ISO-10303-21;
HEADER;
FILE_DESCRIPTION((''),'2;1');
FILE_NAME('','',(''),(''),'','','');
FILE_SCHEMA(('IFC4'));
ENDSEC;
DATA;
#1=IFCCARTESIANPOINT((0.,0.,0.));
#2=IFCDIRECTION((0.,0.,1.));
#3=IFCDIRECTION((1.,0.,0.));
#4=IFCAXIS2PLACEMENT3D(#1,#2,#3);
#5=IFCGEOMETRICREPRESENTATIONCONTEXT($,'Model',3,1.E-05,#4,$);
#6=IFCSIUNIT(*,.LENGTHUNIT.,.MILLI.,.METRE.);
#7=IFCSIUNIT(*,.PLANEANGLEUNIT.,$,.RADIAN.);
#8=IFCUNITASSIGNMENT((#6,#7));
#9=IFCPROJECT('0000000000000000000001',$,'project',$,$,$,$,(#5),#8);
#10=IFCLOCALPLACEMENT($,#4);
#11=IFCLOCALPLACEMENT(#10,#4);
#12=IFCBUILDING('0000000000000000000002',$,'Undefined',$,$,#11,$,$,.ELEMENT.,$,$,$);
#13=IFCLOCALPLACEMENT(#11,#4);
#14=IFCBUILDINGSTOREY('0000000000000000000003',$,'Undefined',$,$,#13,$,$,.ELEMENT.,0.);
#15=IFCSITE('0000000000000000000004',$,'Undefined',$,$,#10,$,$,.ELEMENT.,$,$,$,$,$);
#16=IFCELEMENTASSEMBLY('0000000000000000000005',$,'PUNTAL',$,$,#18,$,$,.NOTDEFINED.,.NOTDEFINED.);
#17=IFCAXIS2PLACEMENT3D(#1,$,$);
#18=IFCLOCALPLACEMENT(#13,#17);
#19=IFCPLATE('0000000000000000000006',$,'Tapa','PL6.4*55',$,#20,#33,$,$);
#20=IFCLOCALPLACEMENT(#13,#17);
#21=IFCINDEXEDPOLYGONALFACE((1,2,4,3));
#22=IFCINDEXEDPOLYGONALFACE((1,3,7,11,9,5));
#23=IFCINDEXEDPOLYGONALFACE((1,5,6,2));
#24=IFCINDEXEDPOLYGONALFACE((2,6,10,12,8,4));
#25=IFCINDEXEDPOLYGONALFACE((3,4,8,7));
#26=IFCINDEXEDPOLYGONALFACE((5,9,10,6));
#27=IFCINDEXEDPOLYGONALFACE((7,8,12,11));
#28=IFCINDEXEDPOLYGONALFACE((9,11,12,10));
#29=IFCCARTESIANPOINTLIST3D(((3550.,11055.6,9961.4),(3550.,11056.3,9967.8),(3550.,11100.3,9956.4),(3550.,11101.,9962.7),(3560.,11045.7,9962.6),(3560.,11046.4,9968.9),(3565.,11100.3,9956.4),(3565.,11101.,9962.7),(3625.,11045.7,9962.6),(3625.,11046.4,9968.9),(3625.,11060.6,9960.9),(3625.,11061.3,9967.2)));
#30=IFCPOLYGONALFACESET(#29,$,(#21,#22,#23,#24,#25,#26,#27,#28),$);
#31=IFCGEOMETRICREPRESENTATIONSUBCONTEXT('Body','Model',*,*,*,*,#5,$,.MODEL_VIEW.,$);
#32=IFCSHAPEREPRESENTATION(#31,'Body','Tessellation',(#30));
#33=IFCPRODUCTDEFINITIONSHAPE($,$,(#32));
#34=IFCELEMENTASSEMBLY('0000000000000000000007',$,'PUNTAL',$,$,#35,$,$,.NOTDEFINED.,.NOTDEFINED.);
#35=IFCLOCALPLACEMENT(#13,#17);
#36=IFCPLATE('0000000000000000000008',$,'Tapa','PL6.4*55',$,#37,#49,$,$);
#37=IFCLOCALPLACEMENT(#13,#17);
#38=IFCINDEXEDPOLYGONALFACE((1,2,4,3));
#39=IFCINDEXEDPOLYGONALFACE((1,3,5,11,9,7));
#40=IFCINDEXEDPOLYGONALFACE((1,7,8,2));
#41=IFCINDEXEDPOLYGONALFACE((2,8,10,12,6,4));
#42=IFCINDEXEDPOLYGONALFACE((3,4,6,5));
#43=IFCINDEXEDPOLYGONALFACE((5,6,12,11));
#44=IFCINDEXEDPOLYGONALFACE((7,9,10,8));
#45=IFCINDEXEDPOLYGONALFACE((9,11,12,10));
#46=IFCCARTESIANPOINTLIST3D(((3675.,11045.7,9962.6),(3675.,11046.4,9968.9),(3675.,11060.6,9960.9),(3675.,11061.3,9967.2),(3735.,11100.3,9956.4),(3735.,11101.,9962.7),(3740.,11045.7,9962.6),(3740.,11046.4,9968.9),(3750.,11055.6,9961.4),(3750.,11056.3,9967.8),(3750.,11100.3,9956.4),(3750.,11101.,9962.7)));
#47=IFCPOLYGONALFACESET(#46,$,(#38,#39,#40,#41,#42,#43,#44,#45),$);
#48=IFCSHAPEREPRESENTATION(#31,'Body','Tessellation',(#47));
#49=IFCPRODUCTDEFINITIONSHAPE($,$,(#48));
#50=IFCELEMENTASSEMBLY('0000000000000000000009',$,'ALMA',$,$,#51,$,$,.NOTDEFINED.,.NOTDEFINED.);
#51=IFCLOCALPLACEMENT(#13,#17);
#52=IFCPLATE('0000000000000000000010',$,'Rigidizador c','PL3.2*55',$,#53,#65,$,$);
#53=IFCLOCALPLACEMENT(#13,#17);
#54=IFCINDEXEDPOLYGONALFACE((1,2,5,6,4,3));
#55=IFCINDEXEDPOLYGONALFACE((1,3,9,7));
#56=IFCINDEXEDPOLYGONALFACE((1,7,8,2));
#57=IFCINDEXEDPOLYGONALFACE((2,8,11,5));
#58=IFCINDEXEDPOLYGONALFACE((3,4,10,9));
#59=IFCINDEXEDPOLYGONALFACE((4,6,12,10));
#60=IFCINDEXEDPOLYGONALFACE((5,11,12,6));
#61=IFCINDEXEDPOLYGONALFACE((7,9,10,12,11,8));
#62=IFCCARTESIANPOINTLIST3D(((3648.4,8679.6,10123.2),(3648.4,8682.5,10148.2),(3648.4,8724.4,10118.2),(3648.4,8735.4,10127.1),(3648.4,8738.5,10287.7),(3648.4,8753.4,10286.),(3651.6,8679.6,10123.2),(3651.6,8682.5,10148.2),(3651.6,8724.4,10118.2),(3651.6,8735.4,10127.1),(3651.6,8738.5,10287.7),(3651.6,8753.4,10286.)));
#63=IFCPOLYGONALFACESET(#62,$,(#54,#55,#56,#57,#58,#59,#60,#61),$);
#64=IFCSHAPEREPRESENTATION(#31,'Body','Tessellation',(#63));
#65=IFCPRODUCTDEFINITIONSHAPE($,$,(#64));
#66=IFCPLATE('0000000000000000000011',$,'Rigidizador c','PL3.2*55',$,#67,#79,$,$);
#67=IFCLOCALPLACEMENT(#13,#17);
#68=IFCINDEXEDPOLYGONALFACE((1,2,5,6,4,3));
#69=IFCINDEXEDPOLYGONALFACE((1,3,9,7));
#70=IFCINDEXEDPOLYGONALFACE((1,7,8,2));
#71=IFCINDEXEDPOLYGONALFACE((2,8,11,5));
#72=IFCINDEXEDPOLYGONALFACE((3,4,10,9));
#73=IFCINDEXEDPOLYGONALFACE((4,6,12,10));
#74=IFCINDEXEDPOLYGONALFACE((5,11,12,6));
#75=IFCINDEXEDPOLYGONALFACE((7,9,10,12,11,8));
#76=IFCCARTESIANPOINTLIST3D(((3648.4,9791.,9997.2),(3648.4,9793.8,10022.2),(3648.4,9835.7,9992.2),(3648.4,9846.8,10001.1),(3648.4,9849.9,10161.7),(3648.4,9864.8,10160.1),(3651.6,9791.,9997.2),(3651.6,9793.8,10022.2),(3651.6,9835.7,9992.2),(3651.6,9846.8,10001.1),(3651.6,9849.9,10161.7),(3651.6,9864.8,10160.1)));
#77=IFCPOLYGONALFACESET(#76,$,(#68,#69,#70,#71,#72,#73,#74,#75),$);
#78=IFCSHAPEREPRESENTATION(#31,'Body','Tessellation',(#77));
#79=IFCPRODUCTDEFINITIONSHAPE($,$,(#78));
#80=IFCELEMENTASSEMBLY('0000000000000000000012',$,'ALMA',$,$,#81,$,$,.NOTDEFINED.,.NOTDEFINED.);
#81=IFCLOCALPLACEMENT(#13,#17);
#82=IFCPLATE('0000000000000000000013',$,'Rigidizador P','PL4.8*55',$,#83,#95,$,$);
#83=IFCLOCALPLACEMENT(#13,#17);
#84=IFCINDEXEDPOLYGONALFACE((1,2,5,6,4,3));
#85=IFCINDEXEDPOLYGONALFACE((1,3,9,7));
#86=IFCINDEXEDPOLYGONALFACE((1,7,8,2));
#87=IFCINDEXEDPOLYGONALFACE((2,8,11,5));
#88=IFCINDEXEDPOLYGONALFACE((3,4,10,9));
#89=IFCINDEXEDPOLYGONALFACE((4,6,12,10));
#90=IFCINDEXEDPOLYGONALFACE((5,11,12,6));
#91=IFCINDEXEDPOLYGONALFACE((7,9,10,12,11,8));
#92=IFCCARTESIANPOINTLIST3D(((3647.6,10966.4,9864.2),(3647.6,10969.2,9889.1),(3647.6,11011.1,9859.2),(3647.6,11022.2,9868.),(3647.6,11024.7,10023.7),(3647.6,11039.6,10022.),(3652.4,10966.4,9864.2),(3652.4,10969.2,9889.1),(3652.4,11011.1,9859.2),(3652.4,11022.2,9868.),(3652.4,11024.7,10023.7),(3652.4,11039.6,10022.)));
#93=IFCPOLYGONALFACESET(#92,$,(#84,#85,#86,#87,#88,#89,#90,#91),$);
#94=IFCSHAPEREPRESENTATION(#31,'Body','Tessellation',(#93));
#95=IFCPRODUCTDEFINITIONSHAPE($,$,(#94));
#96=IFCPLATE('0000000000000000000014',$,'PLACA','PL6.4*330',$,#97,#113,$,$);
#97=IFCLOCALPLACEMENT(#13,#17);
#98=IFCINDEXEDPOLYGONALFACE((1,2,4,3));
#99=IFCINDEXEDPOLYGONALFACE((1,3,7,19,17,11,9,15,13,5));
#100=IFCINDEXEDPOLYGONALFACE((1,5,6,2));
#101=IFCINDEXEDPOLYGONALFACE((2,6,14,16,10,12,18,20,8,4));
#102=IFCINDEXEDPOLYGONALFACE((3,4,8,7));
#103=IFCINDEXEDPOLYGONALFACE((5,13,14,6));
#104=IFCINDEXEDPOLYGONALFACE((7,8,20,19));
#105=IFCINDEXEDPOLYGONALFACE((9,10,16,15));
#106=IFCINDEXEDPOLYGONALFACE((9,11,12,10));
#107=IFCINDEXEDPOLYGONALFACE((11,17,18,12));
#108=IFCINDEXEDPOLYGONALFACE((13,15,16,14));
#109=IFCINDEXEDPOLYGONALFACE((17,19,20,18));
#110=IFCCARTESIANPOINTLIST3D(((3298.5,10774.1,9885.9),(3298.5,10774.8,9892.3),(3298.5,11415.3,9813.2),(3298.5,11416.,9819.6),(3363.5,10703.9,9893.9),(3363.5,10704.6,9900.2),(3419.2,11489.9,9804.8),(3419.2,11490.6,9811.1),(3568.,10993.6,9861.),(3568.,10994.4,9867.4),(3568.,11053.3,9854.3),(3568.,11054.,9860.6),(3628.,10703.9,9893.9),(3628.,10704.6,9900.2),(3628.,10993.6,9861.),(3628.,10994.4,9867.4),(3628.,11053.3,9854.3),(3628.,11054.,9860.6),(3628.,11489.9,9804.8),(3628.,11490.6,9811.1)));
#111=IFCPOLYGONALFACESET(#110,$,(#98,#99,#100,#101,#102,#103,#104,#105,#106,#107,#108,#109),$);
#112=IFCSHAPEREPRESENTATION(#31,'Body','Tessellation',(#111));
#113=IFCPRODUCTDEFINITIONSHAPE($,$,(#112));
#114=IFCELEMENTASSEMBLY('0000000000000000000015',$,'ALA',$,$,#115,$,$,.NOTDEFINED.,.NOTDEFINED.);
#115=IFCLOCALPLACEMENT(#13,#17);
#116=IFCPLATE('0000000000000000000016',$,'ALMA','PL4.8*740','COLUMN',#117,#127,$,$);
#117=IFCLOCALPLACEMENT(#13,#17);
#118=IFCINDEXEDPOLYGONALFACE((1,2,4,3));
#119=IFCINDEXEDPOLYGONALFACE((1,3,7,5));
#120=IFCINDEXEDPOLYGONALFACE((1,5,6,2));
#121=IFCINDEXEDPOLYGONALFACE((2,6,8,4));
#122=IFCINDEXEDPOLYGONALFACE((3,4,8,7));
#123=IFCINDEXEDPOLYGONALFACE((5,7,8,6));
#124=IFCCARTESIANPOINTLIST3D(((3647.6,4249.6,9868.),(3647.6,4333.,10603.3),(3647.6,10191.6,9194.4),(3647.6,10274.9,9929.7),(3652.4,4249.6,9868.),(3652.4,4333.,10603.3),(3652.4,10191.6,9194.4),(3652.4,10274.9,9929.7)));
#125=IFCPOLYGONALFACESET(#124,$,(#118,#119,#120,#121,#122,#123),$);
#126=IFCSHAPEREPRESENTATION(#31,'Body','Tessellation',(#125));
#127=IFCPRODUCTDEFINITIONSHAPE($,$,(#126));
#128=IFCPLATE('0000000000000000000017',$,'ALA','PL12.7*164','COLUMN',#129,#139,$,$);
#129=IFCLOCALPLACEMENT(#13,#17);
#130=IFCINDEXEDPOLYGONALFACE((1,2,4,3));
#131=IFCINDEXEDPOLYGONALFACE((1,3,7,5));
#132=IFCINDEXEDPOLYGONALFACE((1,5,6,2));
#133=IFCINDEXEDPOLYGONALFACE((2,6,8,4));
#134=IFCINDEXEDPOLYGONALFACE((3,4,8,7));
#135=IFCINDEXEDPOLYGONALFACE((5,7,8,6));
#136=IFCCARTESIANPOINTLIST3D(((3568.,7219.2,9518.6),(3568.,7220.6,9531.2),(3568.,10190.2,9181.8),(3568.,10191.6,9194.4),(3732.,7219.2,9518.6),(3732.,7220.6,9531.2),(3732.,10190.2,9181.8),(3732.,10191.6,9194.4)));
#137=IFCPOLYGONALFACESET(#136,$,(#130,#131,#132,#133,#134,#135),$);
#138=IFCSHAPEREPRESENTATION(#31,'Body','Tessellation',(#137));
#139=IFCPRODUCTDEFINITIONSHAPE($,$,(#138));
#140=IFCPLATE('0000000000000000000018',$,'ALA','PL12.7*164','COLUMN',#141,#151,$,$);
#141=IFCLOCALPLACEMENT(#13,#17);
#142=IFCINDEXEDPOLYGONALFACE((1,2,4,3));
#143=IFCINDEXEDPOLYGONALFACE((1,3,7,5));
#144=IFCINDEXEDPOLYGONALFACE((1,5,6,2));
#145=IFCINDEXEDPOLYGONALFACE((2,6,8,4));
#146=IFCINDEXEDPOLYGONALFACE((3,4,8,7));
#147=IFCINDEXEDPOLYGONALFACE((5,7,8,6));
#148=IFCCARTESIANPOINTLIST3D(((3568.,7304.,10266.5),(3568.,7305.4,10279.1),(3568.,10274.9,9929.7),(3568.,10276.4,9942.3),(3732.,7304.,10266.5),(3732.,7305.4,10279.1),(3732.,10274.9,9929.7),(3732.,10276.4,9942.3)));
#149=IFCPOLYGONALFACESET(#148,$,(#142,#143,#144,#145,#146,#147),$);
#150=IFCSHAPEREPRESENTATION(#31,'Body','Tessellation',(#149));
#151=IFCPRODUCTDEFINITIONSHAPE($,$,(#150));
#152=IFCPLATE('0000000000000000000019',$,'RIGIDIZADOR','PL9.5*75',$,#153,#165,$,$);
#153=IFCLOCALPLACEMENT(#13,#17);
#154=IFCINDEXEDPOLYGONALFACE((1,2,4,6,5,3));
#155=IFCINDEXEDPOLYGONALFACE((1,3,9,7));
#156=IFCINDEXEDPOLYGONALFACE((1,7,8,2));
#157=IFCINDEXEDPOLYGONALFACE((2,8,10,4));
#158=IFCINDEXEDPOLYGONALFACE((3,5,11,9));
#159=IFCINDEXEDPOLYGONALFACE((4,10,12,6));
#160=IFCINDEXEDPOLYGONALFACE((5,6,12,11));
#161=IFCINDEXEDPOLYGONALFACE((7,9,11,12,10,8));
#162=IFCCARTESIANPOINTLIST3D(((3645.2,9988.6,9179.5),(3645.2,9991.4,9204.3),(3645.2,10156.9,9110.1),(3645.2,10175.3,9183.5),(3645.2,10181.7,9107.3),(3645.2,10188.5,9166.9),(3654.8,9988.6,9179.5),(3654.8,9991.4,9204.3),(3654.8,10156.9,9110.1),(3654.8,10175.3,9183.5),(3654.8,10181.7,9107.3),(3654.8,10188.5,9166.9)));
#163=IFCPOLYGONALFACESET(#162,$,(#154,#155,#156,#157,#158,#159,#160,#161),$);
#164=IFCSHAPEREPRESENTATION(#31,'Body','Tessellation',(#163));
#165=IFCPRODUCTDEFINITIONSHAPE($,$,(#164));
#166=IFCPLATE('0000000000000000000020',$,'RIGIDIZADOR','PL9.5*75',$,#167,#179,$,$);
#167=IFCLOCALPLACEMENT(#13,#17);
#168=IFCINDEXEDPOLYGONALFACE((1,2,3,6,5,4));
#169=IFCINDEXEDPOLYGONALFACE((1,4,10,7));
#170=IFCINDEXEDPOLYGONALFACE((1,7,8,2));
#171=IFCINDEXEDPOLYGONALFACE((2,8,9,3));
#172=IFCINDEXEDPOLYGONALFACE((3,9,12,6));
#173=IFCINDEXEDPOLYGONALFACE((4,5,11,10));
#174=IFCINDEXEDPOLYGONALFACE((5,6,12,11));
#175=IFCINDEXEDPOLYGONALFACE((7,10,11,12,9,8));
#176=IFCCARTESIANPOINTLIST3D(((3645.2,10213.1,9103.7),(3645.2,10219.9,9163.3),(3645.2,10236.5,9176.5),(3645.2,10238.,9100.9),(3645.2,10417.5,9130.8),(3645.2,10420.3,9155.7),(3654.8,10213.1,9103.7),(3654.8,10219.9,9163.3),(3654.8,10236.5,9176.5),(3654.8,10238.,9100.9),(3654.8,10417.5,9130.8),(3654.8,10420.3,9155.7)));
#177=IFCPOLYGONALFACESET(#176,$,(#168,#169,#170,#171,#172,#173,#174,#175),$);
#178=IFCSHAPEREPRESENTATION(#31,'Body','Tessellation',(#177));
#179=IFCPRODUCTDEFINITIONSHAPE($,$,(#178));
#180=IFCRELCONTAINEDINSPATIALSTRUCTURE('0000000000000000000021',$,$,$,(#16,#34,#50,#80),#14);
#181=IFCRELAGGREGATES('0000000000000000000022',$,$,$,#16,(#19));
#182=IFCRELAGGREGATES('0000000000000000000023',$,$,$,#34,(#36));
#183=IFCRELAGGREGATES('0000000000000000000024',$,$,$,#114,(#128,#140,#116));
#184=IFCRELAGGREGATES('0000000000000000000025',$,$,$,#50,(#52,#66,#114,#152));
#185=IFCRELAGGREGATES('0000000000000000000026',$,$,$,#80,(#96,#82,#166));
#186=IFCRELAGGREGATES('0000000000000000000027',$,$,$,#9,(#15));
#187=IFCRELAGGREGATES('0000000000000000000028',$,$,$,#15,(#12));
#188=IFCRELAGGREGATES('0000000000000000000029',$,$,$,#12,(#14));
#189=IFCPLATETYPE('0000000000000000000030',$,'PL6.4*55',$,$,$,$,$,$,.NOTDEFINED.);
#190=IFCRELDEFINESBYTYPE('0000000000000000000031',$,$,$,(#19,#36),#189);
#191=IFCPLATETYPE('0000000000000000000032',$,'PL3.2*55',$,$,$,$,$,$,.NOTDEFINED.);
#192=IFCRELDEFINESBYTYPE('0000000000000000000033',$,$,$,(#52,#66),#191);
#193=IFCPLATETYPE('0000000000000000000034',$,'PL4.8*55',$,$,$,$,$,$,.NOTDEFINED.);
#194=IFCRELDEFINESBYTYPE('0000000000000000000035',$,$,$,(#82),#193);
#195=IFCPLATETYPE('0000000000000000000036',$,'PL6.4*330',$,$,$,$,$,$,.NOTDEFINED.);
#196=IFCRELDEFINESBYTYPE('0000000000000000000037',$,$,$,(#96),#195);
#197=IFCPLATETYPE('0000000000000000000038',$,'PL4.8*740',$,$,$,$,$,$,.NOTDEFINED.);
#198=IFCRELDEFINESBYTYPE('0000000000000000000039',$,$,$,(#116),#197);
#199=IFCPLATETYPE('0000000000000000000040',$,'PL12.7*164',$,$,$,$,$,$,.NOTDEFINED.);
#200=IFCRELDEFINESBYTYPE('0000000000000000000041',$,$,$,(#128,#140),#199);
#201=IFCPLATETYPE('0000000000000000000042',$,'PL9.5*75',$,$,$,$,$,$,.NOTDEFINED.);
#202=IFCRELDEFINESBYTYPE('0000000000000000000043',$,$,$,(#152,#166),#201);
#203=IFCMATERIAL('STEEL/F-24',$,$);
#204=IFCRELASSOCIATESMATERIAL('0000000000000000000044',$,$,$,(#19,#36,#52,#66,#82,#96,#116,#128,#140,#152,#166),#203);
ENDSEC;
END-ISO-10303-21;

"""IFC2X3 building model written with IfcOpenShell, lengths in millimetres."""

from ifc_helpers import new_model, si_unit, frame, origin_with_axes, place, context, subcontext, project, spatial, polyline, outline, extrude, boolean, material, type_object, element, aggregate, save


model = new_model("IFC2X3")

# Units and contexts
model_context = context("Model", 3, precision=1e-05, world=origin_with_axes())
body_context = subcontext(model_context, "Body", "Model", "MODEL_VIEW")
ifc_project = project(units=[si_unit("LENGTHUNIT", "METRE", prefix="MILLI"), si_unit("PLANEANGLEUNIT", "RADIAN")], contexts=[model_context])

# Site, building, storey
site_placement = place(None, origin_with_axes())
site = spatial("IfcSite", under=ifc_project, at=site_placement, Name="Undefined", CompositionType="ELEMENT")
building_placement = place(site_placement, origin_with_axes())
building = spatial("IfcBuilding", under=site, at=building_placement, Name="Undefined", CompositionType="ELEMENT")
storey_placement = place(building_placement, origin_with_axes())
storey = spatial("IfcBuildingStorey", under=building, at=storey_placement, Name="Undefined", CompositionType="ELEMENT", Elevation=0.0)

# Element assemblies, plates
assembly_1_placement = place(storey_placement, origin_with_axes())
assembly_1 = element("IfcElementAssembly", 1, at=assembly_1_placement, inside=storey, Name="PUNTAL", AssemblyPlace="NOTDEFINED", PredefinedType="NOTDEFINED")
ifc_material_1 = material(Name="STEEL/F-24")
plate_type_1 = type_object("IfcPlateType", Name="PL6.4*55", PredefinedType="NOTDEFINED")
plate_1_placement = place(assembly_1_placement, frame((3625.0, 11046.0, 9965.7), z_axis=(0.0, -0.112644, -0.993635), x_axis=(-1.0, 0.0, 0.0)))
plate_1 = element("IfcPlate", 2, at=plate_1_placement, type_object=plate_type_1, material=ifc_material_1, Name="Tapa", Description="PL6.4*55", context=body_context, shape_type="SweptSolid", body=[
    extrude(outline(polyline([(0.0, 0.0), (65.0, 0.0), (75.0, 10.0), (75.0, 55.0), (60.0, 55.0), (0.0, 15.0), (0.0, 0.0)])), frame((0.0, 0.0, -3.2), z_axis=(0.0, 0.0, 1.0), x_axis=(1.0, 0.0, 0.0)), (0.0, 0.0, 1.0), 6.4),
])
aggregate(assembly_1, [plate_1])
assembly_2_placement = place(storey_placement, origin_with_axes())
assembly_2 = element("IfcElementAssembly", 3, at=assembly_2_placement, inside=storey, Name="PUNTAL", AssemblyPlace="NOTDEFINED", PredefinedType="NOTDEFINED")
plate_2_placement = place(assembly_2_placement, frame((3675.0, 11046.0, 9965.7), z_axis=(0.0, 0.112644, 0.993635), x_axis=(1.0, 0.0, 0.0)))
plate_2 = element("IfcPlate", 4, at=plate_2_placement, type_object=plate_type_1, material=ifc_material_1, Name="Tapa", Description="PL6.4*55", context=body_context, shape_type="SweptSolid", body=[
    extrude(outline(polyline([(0.0, 0.0), (65.0, 0.0), (75.0, 10.0), (75.0, 55.0), (60.0, 55.0), (0.0, 15.0), (0.0, 0.0)])), frame((0.0, 0.0, -3.2), z_axis=(0.0, 0.0, 1.0), x_axis=(1.0, 0.0, 0.0)), (0.0, 0.0, 1.0), 6.4),
])
aggregate(assembly_2, [plate_2])

# Element assemblies, plates
assembly_3_placement = place(storey_placement, origin_with_axes())
assembly_3 = element("IfcElementAssembly", 5, at=assembly_3_placement, inside=storey, Name="ALMA", AssemblyPlace="NOTDEFINED", PredefinedType="NOTDEFINED")
plate_type_2 = type_object("IfcPlateType", Name="PL3.2*55", PredefinedType="NOTDEFINED")
plate_3_placement = place(assembly_3_placement, frame((3650.0, 8753.4, 10286.0), z_axis=(1.0, 0.0, 0.0), x_axis=(0.0, -0.993635, 0.112644)))
plate_3 = element("IfcPlate", 6, at=plate_3_placement, type_object=plate_type_2, material=ifc_material_1, Name="Rigidizador c", Description="PL3.2*55", context=body_context, shape_type="SweptSolid", body=[
    extrude(outline(polyline([(0.0, 0.0), (15.0, 0.0), (55.0, 145.0), (55.0, 170.1), (10.0, 170.0), (0.0, 160.0), (0.0, 0.0)])), frame((0.0, 0.0, -1.6), z_axis=(0.0, 0.0, 1.0), x_axis=(1.0, 0.0, 0.0)), (0.0, 0.0, 1.0), 3.2),
])
plate_4_placement = place(assembly_3_placement, frame((3650.0, 9864.8, 10160.1), z_axis=(1.0, 0.0, 0.0), x_axis=(0.0, -0.993635, 0.112644)))
plate_4 = element("IfcPlate", 7, at=plate_4_placement, type_object=plate_type_2, material=ifc_material_1, Name="Rigidizador c", Description="PL3.2*55", context=body_context, shape_type="SweptSolid", body=[
    extrude(outline(polyline([(0.0, 0.0), (15.0, 0.0), (55.0, 145.0), (55.0, 170.1), (10.0, 170.0), (0.0, 160.0), (0.0, 0.0)])), frame((0.0, 0.0, -1.6), z_axis=(0.0, 0.0, 1.0), x_axis=(1.0, 0.0, 0.0)), (0.0, 0.0, 1.0), 3.2),
])
assembly_4_placement = place(storey_placement, origin_with_axes())
assembly_4 = element("IfcElementAssembly", 8, at=assembly_4_placement, inside=storey, Name="ALMA", AssemblyPlace="NOTDEFINED", PredefinedType="NOTDEFINED")
plate_type_3 = type_object("IfcPlateType", Name="PL4.8*55", PredefinedType="NOTDEFINED")
plate_5_placement = place(assembly_4_placement, frame((3650.0, 11039.6, 10022.0), z_axis=(1.0, 0.0, 0.0), x_axis=(0.0, -0.993635, 0.112644)))
plate_5 = element("IfcPlate", 9, at=plate_5_placement, type_object=plate_type_3, material=ifc_material_1, Name="Rigidizador P", Description="PL4.8*55", context=body_context, shape_type="SweptSolid", body=[
    extrude(outline(polyline([(0.0, 0.0), (15.0, 0.0), (55.0, 140.0), (55.0, 165.0), (10.0, 165.0), (0.0, 155.0), (0.0, 0.0)])), frame((0.0, 0.0, -2.4), z_axis=(0.0, 0.0, 1.0), x_axis=(1.0, 0.0, 0.0)), (0.0, 0.0, 1.0), 4.8),
])
plate_type_4 = type_object("IfcPlateType", Name="PL6.4*330", PredefinedType="NOTDEFINED")
plate_6_placement = place(assembly_4_placement, frame((3628.0, 11490.3, 9808.0), z_axis=(-0.000011, -0.112644, -0.993635), x_axis=(0.0, -0.993635, 0.112644)))
plate_6 = element("IfcPlate", 10, at=plate_6_placement, type_object=plate_type_4, material=ifc_material_1, Name="PLACA", Description="PL6.4*330", context=body_context, shape_type="CSG", body=[
    boolean("DIFFERENCE", extrude(outline(polyline([(0.0, 0.0), (791.0, 0.0), (791.0, 264.5), (720.4, 329.5), (75.1, 329.5), (0.0, 208.8), (0.0, 0.0)])), frame((0.0, 0.0, -3.2), z_axis=(0.0, 0.0, 1.0), x_axis=(1.0, 0.0, 0.0)), (0.0, 0.0, 1.0), 6.4), extrude(outline(polyline([(0.0, 0.0), (60.0, 0.0), (60.0, 60.0), (0.0, 60.0), (0.0, 0.0)])), frame((439.4, 60.0, -5.0), z_axis=(-0.000249, -0.000011, 1.0), x_axis=(0.0, -1.0, -0.000011)), (0.0, 0.0, 1.0), 12.0)),
])
assembly_5_placement = place(assembly_3_placement, origin_with_axes())
assembly_5 = element("IfcElementAssembly", 11, at=assembly_5_placement, Name="ALA", AssemblyPlace="NOTDEFINED", PredefinedType="NOTDEFINED")
plate_type_5 = type_object("IfcPlateType", Name="PL4.8*740", PredefinedType="NOTDEFINED")
plate_7_placement = place(assembly_5_placement, frame((3650.0, 10233.3, 9562.0), z_axis=(-1.0, 0.0, 0.0), x_axis=(0.0, -0.993635, 0.112644)))
plate_7 = element("IfcPlate", 12, at=plate_7_placement, type_object=plate_type_5, material=ifc_material_1, Name="ALMA", Description="PL4.8*740", ObjectType="COLUMN", context=body_context, shape_type="SweptSolid", body=[
    extrude(outline(polyline([(0.0, -370.0), (0.0, 370.0), (5980.0, 370.0), (5980.0, -370.0), (0.0, -370.0)])), frame((0.0, 0.0, -2.4), z_axis=(0.0, 0.0, 1.0), x_axis=(1.0, 0.0, 0.0)), (0.0, 0.0, 1.0), 4.8),
])
plate_type_6 = type_object("IfcPlateType", Name="PL12.7*164", PredefinedType="NOTDEFINED")
plate_8_placement = place(assembly_5_placement, frame((3650.0, 10190.9, 9188.1), z_axis=(0.0, 0.112644, 0.993635), x_axis=(0.0, -0.993635, 0.112644)))
plate_8 = element("IfcPlate", 13, at=plate_8_placement, type_object=plate_type_6, material=ifc_material_1, Name="ALA", Description="PL12.7*164", ObjectType="COLUMN", context=body_context, shape_type="SweptSolid", body=[
    extrude(outline(polyline([(0.0, -82.0), (0.0, 82.0), (2990.0, 82.0), (2990.0, -82.0), (0.0, -82.0)])), frame((0.0, 0.0, -6.3), z_axis=(0.0, 0.0, 1.0), x_axis=(1.0, 0.0, 0.0)), (0.0, 0.0, 1.0), 12.7),
])
plate_9_placement = place(assembly_5_placement, frame((3650.0, 10275.7, 9936.0), z_axis=(0.0, 0.112644, 0.993635), x_axis=(0.0, -0.993635, 0.112644)))
plate_9 = element("IfcPlate", 14, at=plate_9_placement, type_object=plate_type_6, material=ifc_material_1, Name="ALA", Description="PL12.7*164", ObjectType="COLUMN", context=body_context, shape_type="SweptSolid", body=[
    extrude(outline(polyline([(0.0, -82.0), (0.0, 82.0), (2990.0, 82.0), (2990.0, -82.0), (0.0, -82.0)])), frame((0.0, 0.0, -6.3), z_axis=(0.0, 0.0, 1.0), x_axis=(1.0, 0.0, 0.0)), (0.0, 0.0, 1.0), 12.7),
])
aggregate(assembly_5, [plate_8, plate_9, plate_7])

# Plates
plate_type_7 = type_object("IfcPlateType", Name="PL9.5*75", PredefinedType="NOTDEFINED")
plate_10_placement = place(assembly_3_placement, frame((3650.0, 10190.2, 9181.8), z_axis=(1.0, 0.0, 0.0), x_axis=(0.0, -0.993635, 0.112644)))
plate_10 = element("IfcPlate", 15, at=plate_10_placement, type_object=plate_type_7, material=ifc_material_1, Name="RIGIDIZADOR", Description="PL9.5*75", context=body_context, shape_type="SweptSolid", body=[
    extrude(outline(polyline([(0.0, 15.0), (15.0, 0.0), (200.0, 0.0), (200.0, 25.0), (25.0, 75.0), (0.0, 75.0), (0.0, 15.0)])), frame((0.0, 0.0, -4.8), z_axis=(0.0, 0.0, 1.0), x_axis=(1.0, 0.0, 0.0)), (0.0, 0.0, 1.0), 9.5),
])
plate_11_placement = place(assembly_4_placement, frame((3650.0, 10221.6, 9178.2), z_axis=(-1.0, 0.0, 0.0), x_axis=(0.0, 0.993635, -0.112644)))
plate_11 = element("IfcPlate", 16, at=plate_11_placement, type_object=plate_type_7, material=ifc_material_1, Name="RIGIDIZADOR", Description="PL9.5*75", context=body_context, shape_type="SweptSolid", body=[
    extrude(outline(polyline([(0.0, 15.0), (15.0, 0.0), (200.0, 0.0), (200.0, 25.0), (25.0, 75.0), (0.0, 75.0), (0.0, 15.0)])), frame((0.0, 0.0, -4.8), z_axis=(0.0, 0.0, 1.0), x_axis=(1.0, 0.0, 0.0)), (0.0, 0.0, 1.0), 9.5),
])

aggregate(assembly_3, [plate_3, plate_4, assembly_5, plate_10])

aggregate(assembly_4, [plate_6, plate_5, plate_11])

save(model, "model.ifc")
